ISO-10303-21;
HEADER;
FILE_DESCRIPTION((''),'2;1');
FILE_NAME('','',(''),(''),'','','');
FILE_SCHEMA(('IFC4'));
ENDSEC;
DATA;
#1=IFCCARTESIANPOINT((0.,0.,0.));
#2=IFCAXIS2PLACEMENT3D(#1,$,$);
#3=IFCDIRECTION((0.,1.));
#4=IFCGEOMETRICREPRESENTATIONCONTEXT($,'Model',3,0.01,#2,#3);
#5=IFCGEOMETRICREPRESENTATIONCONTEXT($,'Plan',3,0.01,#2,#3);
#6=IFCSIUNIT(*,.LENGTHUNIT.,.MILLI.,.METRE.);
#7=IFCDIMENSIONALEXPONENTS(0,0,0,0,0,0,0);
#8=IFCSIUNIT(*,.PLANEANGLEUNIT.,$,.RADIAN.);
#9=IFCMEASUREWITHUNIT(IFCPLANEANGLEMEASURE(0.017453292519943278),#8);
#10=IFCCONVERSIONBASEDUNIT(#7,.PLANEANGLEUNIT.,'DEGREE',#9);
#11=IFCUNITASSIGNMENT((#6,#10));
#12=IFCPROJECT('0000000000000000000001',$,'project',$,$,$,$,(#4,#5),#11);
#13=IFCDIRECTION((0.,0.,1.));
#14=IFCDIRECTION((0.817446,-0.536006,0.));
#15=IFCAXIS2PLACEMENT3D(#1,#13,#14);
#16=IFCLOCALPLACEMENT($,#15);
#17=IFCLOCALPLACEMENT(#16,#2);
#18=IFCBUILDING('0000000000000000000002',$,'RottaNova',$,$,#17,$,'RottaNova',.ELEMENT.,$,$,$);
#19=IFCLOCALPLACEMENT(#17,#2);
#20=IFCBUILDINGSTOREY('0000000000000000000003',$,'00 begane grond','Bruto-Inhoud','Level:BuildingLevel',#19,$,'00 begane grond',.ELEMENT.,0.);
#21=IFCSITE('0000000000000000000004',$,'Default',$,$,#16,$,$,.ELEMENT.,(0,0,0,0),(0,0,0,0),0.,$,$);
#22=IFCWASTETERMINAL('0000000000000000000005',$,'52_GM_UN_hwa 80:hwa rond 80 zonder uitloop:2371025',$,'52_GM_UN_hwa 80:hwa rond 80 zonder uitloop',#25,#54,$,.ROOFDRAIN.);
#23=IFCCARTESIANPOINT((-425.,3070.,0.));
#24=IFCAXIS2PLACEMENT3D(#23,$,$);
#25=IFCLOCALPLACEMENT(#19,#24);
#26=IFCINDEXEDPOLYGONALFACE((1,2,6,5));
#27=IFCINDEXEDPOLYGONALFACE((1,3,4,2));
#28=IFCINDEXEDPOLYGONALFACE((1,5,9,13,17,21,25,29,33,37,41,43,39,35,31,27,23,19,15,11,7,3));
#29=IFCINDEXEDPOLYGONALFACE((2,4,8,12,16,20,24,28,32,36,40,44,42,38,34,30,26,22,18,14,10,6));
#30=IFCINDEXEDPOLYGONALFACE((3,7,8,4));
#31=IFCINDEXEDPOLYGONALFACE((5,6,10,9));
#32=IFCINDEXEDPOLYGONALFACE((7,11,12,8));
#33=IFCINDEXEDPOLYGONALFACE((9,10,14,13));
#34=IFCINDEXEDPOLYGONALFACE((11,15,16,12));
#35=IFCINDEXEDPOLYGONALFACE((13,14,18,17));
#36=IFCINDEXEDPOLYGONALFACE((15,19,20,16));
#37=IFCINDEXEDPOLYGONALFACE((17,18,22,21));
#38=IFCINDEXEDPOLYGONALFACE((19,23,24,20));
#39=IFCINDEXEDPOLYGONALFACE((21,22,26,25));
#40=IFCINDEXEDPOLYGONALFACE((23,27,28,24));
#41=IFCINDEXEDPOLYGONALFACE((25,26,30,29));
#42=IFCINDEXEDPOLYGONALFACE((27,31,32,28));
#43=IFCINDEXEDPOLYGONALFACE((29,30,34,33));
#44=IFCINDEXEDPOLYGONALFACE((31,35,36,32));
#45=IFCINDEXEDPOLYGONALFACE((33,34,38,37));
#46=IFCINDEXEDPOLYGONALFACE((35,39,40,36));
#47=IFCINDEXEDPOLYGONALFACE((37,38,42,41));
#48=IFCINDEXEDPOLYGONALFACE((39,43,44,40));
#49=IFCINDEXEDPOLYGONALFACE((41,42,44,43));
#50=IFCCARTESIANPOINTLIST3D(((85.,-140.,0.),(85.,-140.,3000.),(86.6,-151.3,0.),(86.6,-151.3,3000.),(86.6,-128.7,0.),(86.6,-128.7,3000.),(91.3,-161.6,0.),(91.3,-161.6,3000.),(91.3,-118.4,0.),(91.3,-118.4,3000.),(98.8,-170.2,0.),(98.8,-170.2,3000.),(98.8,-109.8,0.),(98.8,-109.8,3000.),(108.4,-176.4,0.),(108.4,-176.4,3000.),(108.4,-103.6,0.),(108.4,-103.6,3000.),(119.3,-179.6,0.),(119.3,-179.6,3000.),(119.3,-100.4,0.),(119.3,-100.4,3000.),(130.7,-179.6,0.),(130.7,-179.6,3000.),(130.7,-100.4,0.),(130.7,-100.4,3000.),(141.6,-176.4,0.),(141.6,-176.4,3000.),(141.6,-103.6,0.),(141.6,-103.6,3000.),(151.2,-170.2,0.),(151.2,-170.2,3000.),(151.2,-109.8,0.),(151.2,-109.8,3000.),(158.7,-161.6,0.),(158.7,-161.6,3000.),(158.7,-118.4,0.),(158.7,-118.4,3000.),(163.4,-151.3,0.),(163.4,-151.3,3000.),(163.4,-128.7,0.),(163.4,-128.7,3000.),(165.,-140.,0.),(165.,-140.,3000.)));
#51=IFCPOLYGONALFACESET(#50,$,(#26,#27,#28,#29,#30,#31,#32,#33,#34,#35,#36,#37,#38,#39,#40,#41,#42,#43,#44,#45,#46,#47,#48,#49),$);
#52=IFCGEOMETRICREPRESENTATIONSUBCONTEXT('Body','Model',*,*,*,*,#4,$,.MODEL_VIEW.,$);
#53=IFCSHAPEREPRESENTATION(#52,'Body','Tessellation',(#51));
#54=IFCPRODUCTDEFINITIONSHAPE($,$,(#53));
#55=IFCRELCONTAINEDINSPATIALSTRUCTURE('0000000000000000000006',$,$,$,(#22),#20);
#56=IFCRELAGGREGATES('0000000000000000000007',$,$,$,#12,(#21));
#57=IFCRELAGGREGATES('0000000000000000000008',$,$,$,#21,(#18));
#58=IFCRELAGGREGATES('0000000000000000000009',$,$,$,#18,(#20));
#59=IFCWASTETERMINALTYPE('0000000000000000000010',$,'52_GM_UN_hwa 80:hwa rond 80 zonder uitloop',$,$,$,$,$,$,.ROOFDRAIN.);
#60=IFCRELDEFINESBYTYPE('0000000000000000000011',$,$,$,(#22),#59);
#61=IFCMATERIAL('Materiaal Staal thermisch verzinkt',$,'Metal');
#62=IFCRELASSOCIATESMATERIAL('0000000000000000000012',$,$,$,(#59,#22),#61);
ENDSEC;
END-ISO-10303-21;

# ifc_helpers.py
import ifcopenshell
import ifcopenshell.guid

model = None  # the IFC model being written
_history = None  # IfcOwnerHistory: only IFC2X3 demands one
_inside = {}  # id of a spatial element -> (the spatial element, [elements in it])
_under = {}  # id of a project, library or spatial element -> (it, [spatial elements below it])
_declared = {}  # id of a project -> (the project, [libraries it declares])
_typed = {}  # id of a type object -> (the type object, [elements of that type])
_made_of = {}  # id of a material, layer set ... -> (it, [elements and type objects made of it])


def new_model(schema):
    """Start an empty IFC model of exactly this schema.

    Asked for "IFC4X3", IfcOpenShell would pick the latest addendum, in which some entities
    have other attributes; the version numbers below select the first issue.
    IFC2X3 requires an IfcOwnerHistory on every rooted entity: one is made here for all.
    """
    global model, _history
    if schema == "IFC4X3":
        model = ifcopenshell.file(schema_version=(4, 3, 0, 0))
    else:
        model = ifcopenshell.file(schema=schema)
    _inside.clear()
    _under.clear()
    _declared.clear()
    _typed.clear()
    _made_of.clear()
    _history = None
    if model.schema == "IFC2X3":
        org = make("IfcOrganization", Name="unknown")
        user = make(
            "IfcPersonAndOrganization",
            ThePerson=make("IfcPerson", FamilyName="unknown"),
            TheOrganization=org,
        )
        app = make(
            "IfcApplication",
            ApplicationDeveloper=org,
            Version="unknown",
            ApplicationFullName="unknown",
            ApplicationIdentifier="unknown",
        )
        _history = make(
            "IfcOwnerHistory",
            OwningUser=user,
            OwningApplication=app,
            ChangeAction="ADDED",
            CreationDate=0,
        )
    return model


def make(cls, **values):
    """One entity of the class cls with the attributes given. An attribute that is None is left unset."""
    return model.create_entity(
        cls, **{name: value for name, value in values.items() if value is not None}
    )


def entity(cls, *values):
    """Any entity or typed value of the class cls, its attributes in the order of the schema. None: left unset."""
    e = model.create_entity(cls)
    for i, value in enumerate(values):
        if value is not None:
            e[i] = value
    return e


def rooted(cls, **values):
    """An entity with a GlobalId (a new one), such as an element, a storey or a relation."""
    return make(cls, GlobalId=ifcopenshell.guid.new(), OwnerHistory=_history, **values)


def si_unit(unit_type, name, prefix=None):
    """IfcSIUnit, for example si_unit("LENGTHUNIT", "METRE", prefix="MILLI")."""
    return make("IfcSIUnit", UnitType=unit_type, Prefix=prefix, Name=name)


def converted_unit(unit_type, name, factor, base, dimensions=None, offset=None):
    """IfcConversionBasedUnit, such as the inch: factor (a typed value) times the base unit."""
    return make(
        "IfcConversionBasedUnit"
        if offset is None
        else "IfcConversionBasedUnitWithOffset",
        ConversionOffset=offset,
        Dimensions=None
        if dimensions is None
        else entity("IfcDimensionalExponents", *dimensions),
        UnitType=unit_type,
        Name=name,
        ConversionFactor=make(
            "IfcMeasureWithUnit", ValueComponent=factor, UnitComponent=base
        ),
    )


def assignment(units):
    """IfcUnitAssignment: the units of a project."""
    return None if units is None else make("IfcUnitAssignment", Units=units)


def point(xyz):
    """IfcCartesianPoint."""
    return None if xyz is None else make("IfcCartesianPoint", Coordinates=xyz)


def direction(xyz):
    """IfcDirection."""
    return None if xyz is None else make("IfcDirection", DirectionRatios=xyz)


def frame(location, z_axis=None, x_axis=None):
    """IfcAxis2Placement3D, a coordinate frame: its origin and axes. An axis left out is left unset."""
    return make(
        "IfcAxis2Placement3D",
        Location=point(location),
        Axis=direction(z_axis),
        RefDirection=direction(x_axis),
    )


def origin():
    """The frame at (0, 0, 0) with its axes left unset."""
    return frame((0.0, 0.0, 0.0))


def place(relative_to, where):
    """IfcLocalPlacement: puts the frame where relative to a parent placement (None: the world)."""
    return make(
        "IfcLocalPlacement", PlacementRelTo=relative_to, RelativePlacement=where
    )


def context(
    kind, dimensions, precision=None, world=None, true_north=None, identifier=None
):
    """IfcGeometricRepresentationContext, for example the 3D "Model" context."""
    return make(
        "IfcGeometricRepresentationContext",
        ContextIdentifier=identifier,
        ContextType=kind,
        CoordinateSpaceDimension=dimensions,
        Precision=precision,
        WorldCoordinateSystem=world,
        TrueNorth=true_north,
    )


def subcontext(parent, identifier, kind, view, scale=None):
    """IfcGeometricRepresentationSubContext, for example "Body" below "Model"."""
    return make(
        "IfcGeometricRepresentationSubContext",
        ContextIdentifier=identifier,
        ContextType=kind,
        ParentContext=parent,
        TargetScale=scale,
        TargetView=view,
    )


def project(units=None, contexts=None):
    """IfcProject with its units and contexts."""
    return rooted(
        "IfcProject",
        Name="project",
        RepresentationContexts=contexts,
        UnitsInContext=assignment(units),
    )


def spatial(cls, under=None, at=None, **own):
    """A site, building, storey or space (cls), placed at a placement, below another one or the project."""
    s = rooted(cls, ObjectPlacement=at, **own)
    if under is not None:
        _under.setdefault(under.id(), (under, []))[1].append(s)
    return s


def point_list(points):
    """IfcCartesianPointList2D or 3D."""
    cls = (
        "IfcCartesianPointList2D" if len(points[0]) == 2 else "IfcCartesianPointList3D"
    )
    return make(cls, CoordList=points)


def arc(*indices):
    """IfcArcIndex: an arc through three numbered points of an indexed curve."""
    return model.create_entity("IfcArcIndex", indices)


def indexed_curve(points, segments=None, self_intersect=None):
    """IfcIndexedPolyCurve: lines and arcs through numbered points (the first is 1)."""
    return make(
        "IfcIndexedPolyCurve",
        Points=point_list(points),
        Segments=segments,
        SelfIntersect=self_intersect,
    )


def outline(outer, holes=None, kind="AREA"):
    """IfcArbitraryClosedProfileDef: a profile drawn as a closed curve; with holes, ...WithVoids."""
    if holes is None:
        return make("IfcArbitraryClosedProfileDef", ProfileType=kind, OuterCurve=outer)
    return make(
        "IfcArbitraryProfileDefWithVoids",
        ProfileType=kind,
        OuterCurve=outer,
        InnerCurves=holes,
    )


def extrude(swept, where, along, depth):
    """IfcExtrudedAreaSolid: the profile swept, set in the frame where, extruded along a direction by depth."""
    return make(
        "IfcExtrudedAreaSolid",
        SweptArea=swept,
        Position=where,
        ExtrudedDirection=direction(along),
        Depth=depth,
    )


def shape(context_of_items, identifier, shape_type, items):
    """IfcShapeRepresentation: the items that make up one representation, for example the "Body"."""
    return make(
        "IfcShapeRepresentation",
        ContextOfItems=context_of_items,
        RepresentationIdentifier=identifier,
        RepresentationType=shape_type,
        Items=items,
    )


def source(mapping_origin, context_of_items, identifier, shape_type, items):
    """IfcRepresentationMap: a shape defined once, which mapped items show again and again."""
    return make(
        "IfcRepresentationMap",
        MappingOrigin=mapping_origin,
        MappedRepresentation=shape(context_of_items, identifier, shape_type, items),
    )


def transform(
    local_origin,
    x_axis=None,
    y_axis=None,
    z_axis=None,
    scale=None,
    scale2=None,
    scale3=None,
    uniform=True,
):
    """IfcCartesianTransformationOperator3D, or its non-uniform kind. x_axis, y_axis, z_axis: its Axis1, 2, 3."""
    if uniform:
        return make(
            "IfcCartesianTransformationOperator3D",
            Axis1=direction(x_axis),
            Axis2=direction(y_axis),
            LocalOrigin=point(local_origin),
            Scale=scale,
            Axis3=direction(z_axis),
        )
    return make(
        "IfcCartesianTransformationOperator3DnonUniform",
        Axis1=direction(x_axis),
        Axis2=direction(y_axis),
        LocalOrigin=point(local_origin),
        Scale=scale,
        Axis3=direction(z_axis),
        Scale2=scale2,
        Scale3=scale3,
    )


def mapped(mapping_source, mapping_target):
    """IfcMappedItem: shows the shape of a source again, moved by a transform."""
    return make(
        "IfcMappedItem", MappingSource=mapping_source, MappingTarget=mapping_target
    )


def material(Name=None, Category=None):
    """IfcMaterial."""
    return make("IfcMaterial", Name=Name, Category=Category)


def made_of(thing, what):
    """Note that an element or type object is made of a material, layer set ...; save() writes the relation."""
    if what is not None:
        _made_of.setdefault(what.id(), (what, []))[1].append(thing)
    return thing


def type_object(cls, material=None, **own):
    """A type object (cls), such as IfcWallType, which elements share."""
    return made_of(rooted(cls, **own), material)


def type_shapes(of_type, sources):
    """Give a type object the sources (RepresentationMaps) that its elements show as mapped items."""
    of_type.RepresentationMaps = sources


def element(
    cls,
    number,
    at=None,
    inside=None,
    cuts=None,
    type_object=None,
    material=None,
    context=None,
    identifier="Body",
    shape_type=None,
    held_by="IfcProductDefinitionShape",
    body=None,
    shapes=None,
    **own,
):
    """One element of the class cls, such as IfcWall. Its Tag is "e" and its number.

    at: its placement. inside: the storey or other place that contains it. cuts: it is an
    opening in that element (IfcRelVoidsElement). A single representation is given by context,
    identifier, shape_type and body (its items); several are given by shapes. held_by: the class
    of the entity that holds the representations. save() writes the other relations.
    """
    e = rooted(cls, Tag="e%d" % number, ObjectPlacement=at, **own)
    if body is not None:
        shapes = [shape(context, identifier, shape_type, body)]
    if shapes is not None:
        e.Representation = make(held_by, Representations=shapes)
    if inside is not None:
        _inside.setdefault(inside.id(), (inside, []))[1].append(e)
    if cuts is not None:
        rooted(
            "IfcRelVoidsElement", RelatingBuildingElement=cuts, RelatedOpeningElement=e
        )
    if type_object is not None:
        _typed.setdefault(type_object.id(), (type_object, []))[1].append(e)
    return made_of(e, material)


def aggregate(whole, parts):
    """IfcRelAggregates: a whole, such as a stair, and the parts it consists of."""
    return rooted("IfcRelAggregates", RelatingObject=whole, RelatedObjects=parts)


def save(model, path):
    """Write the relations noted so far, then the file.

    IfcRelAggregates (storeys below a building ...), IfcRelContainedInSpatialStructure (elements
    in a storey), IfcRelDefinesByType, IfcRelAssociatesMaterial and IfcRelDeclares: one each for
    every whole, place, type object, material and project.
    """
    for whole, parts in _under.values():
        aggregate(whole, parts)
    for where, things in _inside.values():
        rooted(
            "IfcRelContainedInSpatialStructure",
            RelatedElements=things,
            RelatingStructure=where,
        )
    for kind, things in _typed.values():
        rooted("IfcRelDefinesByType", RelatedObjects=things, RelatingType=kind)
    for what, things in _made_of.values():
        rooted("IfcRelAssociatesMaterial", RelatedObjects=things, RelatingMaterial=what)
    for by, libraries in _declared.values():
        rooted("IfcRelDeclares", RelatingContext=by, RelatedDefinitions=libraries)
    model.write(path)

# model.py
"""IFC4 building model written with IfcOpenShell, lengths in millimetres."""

from ifc_helpers import new_model, entity, si_unit, converted_unit, direction, frame, origin, place, context, subcontext, project, spatial, arc, indexed_curve, outline, extrude, source, transform, mapped, material, type_object, type_shapes, element, save


model = new_model("IFC4")

# Units and contexts
model_context = context("Model", 3, precision=0.01, world=origin(), true_north=direction((0.0, 1.0)))
plan_context = context("Plan", 3, precision=0.01, world=origin(), true_north=direction((0.0, 1.0)))
body_context = subcontext(model_context, "Body", "Model", "MODEL_VIEW")
ifc_project = project(units=[si_unit("LENGTHUNIT", "METRE", prefix="MILLI"), converted_unit("PLANEANGLEUNIT", "DEGREE", entity("IfcPlaneAngleMeasure", 0.017453292519943278), si_unit("PLANEANGLEUNIT", "RADIAN"), dimensions=[0, 0, 0, 0, 0, 0, 0])], contexts=[model_context, plan_context])

# Site, building, storey
site_placement = place(None, frame((0.0, 0.0, 0.0), z_axis=(0.0, 0.0, 1.0), x_axis=(0.817446, -0.536006, 0.0)))
site = spatial("IfcSite", under=ifc_project, at=site_placement, Name="Default", CompositionType="ELEMENT", RefLatitude=(0, 0, 0, 0), RefLongitude=(0, 0, 0, 0), RefElevation=0.0)
building_placement = place(site_placement, origin())
building = spatial("IfcBuilding", under=site, at=building_placement, Name="RottaNova", LongName="RottaNova", CompositionType="ELEMENT")
storey_placement = place(building_placement, origin())
storey = spatial("IfcBuildingStorey", under=building, at=storey_placement, Name="00 begane grond", Description="Bruto-Inhoud", ObjectType="Level:BuildingLevel", LongName="00 begane grond", CompositionType="ELEMENT", Elevation=0.0)

# Waste terminal
ifc_material_1 = material(Name="Materiaal Staal thermisch verzinkt", Category="Metal")
waste_terminal_type = type_object("IfcWasteTerminalType", Name="52_GM_UN_hwa 80:hwa rond 80 zonder uitloop", PredefinedType="ROOFDRAIN", material=ifc_material_1)
shared_shape_1 = source(origin(), body_context, "Body", "SweptSolid", [
    extrude(outline(indexed_curve([(-40.0, 0.0), (0.0, -40.0), (40.0, 0.0), (0.0, 40.0)], segments=[arc(1, 2, 3), arc(3, 4, 1)], self_intersect=False)), frame((125.0, -140.0, 0.0)), (0.0, 0.0, 1.0), 3000.0),
])
type_shapes(waste_terminal_type, [shared_shape_1])
waste_terminal_placement = place(storey_placement, frame((-425.0, 3070.0, 0.0)))
element("IfcWasteTerminal", 1, at=waste_terminal_placement, inside=storey, type_object=waste_terminal_type, material=ifc_material_1, Name="52_GM_UN_hwa 80:hwa rond 80 zonder uitloop:2371025", ObjectType="52_GM_UN_hwa 80:hwa rond 80 zonder uitloop", PredefinedType="ROOFDRAIN", context=body_context, shape_type="MappedRepresentation", body=[
    mapped(shared_shape_1, transform((0.0, 0.0, 0.0), scale=1.0)),
])

save(model, "model.ifc")
